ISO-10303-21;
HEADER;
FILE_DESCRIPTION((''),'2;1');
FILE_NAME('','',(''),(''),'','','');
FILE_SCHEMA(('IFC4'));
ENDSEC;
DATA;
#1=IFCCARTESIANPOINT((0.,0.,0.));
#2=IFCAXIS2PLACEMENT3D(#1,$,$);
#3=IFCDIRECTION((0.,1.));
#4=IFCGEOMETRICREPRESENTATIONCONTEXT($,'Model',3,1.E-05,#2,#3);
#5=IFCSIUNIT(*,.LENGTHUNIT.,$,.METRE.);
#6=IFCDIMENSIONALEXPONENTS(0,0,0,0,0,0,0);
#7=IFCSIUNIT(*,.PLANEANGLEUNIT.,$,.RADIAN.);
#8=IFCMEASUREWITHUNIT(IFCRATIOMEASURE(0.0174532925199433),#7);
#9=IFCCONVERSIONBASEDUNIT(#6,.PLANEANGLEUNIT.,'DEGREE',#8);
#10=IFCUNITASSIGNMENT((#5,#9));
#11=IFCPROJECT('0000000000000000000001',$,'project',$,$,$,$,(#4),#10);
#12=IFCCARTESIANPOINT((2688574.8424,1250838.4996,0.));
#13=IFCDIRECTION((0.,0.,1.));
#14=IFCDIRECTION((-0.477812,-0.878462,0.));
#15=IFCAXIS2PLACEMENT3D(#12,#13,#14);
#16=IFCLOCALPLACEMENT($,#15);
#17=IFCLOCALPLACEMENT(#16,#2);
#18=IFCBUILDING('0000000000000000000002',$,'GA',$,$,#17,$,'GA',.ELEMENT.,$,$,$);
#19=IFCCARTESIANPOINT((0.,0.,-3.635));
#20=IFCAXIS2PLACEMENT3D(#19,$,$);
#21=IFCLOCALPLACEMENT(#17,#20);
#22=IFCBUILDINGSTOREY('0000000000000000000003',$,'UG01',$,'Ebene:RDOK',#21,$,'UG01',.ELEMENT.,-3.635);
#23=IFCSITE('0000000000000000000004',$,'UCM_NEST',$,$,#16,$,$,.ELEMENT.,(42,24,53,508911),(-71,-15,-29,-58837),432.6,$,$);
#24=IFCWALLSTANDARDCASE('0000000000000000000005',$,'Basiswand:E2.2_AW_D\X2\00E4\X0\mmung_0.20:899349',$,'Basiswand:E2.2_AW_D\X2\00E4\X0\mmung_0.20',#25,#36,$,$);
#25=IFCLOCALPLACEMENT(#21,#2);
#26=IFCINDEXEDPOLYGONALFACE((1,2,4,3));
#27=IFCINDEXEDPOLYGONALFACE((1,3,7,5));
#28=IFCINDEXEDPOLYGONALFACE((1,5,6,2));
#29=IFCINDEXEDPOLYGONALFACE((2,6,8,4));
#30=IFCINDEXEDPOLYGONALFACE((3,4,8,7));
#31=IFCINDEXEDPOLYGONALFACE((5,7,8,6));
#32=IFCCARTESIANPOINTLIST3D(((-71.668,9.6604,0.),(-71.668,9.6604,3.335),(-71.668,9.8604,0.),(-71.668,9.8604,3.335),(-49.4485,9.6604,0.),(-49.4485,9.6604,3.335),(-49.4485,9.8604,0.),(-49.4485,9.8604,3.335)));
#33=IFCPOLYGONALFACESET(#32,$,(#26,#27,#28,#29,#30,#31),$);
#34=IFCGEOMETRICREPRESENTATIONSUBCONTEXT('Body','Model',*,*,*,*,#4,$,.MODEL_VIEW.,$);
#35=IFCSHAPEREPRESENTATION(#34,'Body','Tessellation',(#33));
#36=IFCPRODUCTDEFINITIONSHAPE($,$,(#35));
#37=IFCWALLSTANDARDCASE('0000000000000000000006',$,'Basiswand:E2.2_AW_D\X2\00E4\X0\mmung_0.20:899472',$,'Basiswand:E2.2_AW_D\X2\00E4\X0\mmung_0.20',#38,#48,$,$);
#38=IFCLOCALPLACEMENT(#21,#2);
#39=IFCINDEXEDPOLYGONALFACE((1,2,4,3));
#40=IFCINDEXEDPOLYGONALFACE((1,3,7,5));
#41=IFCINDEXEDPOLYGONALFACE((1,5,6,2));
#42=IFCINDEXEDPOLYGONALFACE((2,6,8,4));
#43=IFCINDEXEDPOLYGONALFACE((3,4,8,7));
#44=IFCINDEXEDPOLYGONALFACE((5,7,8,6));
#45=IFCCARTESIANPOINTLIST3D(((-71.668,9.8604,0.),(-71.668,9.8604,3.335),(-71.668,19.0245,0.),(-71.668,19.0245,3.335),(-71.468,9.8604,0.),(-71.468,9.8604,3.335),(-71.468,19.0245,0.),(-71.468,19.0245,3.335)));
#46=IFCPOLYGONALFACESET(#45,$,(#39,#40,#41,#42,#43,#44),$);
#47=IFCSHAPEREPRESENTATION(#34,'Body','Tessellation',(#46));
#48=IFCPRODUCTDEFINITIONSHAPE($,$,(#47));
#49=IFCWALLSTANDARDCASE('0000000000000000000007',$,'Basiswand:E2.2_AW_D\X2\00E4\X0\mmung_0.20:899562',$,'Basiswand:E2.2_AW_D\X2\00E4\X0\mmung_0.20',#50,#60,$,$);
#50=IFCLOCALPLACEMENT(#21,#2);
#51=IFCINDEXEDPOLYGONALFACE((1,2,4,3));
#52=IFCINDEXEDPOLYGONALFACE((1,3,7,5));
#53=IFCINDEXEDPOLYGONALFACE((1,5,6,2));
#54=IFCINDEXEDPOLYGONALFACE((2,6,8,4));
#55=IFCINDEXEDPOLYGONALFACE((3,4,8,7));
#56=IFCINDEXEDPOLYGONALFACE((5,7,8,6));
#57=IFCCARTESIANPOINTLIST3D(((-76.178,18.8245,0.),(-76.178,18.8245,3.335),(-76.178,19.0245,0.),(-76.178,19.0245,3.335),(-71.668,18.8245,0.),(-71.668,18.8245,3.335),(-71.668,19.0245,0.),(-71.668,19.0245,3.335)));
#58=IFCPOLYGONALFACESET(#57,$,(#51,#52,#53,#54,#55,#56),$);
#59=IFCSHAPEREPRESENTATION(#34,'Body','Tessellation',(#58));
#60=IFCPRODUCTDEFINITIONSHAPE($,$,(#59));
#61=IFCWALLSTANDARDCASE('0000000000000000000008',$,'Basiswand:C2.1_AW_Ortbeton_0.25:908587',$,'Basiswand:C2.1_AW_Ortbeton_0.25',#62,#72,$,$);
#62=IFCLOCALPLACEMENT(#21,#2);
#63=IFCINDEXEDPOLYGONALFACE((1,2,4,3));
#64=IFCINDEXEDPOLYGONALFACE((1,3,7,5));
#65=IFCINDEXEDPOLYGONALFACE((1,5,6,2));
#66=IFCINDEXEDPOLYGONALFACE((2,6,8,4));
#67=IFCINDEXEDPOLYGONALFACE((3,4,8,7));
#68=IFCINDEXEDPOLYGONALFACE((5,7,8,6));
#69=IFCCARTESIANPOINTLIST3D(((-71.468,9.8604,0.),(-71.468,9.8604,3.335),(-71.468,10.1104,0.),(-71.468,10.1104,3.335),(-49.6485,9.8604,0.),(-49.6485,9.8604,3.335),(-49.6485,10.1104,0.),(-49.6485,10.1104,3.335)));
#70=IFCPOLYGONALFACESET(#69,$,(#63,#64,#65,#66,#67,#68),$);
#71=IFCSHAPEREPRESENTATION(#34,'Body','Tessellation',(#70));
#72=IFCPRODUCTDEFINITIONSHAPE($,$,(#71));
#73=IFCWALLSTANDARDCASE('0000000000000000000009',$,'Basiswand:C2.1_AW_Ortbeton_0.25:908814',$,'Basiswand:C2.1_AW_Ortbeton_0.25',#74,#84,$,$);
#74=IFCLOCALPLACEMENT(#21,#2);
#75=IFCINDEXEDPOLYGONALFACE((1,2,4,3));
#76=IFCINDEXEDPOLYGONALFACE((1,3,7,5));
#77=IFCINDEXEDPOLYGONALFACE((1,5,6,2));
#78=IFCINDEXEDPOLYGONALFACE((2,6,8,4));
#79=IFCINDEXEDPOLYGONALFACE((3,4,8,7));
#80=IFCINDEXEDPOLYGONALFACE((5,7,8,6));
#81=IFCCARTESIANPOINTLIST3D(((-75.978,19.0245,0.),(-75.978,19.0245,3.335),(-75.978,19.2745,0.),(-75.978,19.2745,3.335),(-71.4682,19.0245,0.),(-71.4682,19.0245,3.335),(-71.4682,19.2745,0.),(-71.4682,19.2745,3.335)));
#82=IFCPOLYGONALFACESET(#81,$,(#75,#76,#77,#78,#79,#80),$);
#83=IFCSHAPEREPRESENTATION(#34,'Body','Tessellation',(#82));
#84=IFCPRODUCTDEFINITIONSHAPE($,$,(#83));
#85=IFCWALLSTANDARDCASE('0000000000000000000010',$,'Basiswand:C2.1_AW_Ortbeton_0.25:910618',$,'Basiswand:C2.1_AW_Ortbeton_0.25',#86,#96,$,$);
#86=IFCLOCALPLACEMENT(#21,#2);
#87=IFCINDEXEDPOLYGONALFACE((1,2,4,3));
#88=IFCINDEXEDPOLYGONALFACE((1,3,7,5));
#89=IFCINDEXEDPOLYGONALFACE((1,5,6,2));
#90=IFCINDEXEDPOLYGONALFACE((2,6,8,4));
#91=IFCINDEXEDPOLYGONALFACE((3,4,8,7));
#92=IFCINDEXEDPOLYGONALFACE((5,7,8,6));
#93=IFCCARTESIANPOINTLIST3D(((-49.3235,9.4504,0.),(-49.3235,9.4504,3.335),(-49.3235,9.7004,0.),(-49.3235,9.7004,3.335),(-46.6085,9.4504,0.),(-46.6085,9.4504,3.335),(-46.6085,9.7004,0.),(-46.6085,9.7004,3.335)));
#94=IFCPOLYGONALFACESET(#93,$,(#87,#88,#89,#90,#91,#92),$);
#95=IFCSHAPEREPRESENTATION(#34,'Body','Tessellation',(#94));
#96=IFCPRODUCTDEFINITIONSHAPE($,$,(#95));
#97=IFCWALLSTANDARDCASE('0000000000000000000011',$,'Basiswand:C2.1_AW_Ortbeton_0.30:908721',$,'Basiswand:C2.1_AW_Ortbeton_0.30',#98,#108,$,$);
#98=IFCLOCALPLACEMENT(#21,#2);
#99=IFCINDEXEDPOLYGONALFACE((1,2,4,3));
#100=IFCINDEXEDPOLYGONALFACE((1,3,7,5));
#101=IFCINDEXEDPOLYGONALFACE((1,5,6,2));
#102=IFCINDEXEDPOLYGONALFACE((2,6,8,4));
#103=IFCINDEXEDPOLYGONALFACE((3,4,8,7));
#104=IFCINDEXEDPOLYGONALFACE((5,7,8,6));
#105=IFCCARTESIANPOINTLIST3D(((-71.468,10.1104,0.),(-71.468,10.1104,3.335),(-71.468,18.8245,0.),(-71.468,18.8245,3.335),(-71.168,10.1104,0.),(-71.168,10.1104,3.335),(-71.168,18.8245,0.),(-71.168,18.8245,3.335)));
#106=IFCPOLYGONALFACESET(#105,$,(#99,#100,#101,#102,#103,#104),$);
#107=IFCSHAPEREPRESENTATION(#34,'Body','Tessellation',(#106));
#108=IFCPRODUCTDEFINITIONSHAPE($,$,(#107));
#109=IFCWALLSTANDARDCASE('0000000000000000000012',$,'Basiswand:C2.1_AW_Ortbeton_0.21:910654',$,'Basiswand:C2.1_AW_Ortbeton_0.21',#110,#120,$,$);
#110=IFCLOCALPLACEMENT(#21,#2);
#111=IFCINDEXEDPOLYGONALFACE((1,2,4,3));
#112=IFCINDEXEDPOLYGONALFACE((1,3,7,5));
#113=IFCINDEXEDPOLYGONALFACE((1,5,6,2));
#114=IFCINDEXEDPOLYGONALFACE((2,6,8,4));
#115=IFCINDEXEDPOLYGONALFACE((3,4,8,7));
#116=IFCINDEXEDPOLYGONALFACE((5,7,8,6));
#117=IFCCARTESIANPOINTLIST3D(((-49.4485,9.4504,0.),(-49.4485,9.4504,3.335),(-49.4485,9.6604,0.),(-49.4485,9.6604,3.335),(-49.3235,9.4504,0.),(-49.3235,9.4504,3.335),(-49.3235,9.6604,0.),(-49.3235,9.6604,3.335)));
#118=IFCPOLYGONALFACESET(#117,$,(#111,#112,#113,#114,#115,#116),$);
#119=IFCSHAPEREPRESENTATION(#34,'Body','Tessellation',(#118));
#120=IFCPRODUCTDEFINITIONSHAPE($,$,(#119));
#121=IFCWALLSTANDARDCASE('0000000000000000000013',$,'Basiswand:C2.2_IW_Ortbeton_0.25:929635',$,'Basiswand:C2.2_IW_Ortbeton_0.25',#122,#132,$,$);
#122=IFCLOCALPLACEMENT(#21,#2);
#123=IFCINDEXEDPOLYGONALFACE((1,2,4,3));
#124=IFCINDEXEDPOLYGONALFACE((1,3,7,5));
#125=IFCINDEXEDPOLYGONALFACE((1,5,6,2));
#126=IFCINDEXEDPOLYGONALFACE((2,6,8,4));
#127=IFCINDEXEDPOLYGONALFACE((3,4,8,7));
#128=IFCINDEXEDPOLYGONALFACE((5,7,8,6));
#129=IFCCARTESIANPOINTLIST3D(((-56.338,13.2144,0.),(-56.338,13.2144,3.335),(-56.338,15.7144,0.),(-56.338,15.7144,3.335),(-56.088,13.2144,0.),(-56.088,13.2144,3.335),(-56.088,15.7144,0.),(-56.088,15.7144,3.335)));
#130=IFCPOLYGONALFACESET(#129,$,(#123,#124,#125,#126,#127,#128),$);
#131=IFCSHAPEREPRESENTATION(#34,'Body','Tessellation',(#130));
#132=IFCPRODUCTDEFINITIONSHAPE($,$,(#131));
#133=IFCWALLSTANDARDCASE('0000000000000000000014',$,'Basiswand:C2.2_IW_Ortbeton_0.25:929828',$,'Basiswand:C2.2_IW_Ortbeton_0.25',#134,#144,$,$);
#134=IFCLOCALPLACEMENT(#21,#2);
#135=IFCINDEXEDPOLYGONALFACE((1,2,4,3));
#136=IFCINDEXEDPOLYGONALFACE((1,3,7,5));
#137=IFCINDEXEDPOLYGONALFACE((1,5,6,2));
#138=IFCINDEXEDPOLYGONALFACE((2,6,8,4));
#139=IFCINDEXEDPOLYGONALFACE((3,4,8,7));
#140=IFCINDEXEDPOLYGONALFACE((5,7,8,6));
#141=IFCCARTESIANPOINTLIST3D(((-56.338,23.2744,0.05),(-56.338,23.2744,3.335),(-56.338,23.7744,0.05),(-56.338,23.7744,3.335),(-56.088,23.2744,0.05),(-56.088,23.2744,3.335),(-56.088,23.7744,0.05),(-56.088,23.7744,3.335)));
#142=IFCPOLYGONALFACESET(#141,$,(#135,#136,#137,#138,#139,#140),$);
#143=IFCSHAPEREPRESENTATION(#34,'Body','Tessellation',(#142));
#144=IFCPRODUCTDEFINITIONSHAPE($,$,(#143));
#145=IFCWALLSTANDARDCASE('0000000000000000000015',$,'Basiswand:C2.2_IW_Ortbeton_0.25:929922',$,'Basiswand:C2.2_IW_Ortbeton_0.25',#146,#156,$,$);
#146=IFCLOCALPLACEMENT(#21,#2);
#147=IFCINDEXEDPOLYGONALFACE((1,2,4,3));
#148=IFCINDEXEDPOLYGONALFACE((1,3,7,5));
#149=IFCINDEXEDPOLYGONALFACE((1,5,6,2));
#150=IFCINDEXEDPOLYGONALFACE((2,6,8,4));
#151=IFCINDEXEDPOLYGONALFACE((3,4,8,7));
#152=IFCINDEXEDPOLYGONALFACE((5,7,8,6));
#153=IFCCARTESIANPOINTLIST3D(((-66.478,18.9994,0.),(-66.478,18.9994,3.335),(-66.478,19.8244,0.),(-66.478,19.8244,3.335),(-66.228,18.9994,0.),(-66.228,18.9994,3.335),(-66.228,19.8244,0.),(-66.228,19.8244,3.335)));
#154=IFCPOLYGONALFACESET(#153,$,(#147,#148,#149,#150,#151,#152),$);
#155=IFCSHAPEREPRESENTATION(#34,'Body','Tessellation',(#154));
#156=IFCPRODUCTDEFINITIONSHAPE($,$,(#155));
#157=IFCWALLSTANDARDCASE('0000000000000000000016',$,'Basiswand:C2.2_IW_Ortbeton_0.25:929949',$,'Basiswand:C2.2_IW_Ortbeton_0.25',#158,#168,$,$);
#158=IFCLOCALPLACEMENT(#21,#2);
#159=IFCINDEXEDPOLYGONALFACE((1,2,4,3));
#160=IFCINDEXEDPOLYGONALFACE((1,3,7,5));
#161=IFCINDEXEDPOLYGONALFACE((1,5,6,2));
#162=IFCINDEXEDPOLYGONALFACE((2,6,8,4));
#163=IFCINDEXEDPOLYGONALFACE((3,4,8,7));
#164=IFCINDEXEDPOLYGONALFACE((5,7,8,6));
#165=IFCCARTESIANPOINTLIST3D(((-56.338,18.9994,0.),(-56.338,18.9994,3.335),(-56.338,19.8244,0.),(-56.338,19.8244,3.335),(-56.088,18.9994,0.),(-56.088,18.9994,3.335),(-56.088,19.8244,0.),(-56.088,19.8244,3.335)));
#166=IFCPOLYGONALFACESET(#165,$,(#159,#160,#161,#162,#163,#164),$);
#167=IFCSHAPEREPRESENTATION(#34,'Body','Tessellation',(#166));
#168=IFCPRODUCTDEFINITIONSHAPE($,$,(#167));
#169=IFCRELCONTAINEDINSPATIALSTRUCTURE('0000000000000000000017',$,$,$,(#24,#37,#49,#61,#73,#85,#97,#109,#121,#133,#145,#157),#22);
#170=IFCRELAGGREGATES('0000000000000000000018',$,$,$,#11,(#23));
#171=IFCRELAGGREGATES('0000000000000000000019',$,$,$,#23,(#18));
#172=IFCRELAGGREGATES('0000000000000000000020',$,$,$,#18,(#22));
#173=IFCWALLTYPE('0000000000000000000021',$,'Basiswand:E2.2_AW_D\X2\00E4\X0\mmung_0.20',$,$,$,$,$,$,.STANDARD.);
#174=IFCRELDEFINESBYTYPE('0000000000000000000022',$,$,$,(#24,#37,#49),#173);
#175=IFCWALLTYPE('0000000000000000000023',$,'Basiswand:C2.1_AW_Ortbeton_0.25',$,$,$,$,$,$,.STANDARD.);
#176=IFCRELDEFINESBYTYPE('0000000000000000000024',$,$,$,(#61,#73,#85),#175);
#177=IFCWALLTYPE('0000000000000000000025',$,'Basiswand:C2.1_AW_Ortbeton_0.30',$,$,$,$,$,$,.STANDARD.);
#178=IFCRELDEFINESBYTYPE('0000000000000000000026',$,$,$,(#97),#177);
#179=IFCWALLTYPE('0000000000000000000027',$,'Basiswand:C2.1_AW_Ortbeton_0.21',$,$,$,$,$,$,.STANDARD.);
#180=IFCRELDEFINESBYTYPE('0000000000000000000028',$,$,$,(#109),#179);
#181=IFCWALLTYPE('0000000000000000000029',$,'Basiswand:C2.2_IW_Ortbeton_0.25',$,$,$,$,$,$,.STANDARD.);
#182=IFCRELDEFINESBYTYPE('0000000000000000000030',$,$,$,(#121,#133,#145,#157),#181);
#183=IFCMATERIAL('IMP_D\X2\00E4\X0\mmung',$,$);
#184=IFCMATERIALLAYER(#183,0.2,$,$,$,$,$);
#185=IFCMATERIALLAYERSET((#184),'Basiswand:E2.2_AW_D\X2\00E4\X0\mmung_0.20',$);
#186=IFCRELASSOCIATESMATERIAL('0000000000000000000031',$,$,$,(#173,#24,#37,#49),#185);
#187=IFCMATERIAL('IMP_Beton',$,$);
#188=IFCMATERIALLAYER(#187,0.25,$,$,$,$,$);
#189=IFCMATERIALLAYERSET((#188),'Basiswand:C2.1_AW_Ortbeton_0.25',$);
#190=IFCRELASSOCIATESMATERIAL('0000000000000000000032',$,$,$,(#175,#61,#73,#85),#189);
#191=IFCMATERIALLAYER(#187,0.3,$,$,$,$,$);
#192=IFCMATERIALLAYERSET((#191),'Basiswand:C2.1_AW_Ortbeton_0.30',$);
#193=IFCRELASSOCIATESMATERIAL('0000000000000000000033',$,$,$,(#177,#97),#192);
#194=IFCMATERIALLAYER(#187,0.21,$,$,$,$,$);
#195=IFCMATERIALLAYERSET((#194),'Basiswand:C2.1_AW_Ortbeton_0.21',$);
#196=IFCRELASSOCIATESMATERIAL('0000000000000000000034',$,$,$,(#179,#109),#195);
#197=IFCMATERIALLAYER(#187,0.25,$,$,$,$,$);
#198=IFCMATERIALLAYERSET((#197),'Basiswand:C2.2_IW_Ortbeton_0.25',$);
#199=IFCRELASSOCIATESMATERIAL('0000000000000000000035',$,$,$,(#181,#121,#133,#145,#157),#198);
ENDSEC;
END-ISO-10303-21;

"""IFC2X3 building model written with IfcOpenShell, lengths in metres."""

from ifc_helpers import new_model, entity, si_unit, converted_unit, direction, frame, frame_2d, origin, place, context, subcontext, project, spatial, polyline, rectangle, extrude, clip, bounded_halfspace, material, layer, layer_set, layer_usage, type_object, element, save


model = new_model("IFC2X3")

# Units and contexts
model_context = context("Model", 3, precision=1e-05, world=origin(), true_north=direction((0.0, 1.0)))
body_context = subcontext(model_context, "Body", "Model", "MODEL_VIEW")
ifc_project = project(units=[si_unit("LENGTHUNIT", "METRE"), converted_unit("PLANEANGLEUNIT", "DEGREE", entity("IfcRatioMeasure", 0.0174532925199433), si_unit("PLANEANGLEUNIT", "RADIAN"), dimensions=[0, 0, 0, 0, 0, 0, 0])], contexts=[model_context])

# Site, building, storey
site_placement = place(None, frame((2688574.8424, 1250838.4996, 0.0), z_axis=(0.0, 0.0, 1.0), x_axis=(-0.477812, -0.878462, 0.0)))
site = spatial("IfcSite", under=ifc_project, at=site_placement, Name="UCM_NEST", CompositionType="ELEMENT", RefLatitude=(42, 24, 53, 508911), RefLongitude=(-71, -15, -29, -58837), RefElevation=432.6)
building_placement = place(site_placement, origin())
building = spatial("IfcBuilding", under=site, at=building_placement, Name="GA", LongName="GA", CompositionType="ELEMENT")
storey_placement = place(building_placement, frame((0.0, 0.0, -3.635)))
storey = spatial("IfcBuildingStorey", under=building, at=storey_placement, Name="UG01", ObjectType="Ebene:RDOK", LongName="UG01", CompositionType="ELEMENT", Elevation=-3.635)

# Walls
ifc_material_1 = material(Name="IMP_Dämmung")
ifc_layer_1 = layer(ifc_material_1, 0.2)
ifc_layer_set_1 = layer_set([ifc_layer_1], Name="Basiswand:E2.2_AW_Dämmung_0.20")
ifc_layer_usage_1 = layer_usage(ifc_layer_set_1, "AXIS2", "NEGATIVE", 0.1)
wall_type_1 = type_object("IfcWallType", Name="Basiswand:E2.2_AW_Dämmung_0.20", PredefinedType="STANDARD", material=ifc_layer_set_1)
wall_1_placement = place(storey_placement, frame((-49.4485, 9.7604, 0.0), z_axis=(0.0, 0.0, 1.0), x_axis=(-1.0, 0.0, 0.0)))
element("IfcWallStandardCase", 1, at=wall_1_placement, inside=storey, type_object=wall_type_1, material=ifc_layer_usage_1, Name="Basiswand:E2.2_AW_Dämmung_0.20:899349", ObjectType="Basiswand:E2.2_AW_Dämmung_0.20", context=body_context, shape_type="SweptSolid", body=[
    extrude(rectangle(XDim=22.2195, YDim=0.2, at=frame_2d((11.1097, 0.0), x_axis=(-1.0, 0.0))), origin(), (0.0, 0.0, 1.0), 3.335),
])
ifc_layer_usage_2 = layer_usage(ifc_layer_set_1, "AXIS2", "NEGATIVE", 0.1)
wall_2_placement = place(storey_placement, frame((-71.568, 9.8604, 0.0), z_axis=(0.0, 0.0, 1.0), x_axis=(0.0, 1.0, 0.0)))
element("IfcWallStandardCase", 2, at=wall_2_placement, inside=storey, type_object=wall_type_1, material=ifc_layer_usage_2, Name="Basiswand:E2.2_AW_Dämmung_0.20:899472", ObjectType="Basiswand:E2.2_AW_Dämmung_0.20", context=body_context, shape_type="SweptSolid", body=[
    extrude(rectangle(XDim=9.164, YDim=0.2, at=frame_2d((4.582, 0.0), x_axis=(-1.0, 0.0))), origin(), (0.0, 0.0, 1.0), 3.335),
])
ifc_layer_usage_3 = layer_usage(ifc_layer_set_1, "AXIS2", "NEGATIVE", 0.1)
wall_3_placement = place(storey_placement, frame((-71.668, 18.9245, 0.0), z_axis=(0.0, 0.0, 1.0), x_axis=(-1.0, 0.0, 0.0)))
element("IfcWallStandardCase", 3, at=wall_3_placement, inside=storey, type_object=wall_type_1, material=ifc_layer_usage_3, Name="Basiswand:E2.2_AW_Dämmung_0.20:899562", ObjectType="Basiswand:E2.2_AW_Dämmung_0.20", context=body_context, shape_type="SweptSolid", body=[
    extrude(rectangle(XDim=4.51, YDim=0.2, at=frame_2d((2.255, 0.0), x_axis=(-1.0, 0.0))), origin(), (0.0, 0.0, 1.0), 3.335),
])
ifc_material_2 = material(Name="IMP_Beton")
ifc_layer_2 = layer(ifc_material_2, 0.25)
ifc_layer_set_2 = layer_set([ifc_layer_2], Name="Basiswand:C2.1_AW_Ortbeton_0.25")
ifc_layer_usage_4 = layer_usage(ifc_layer_set_2, "AXIS2", "NEGATIVE", 0.125)
wall_type_2 = type_object("IfcWallType", Name="Basiswand:C2.1_AW_Ortbeton_0.25", PredefinedType="STANDARD", material=ifc_layer_set_2)
wall_4_placement = place(storey_placement, frame((-71.468, 9.9854, 0.0)))
element("IfcWallStandardCase", 4, at=wall_4_placement, inside=storey, type_object=wall_type_2, material=ifc_layer_usage_4, Name="Basiswand:C2.1_AW_Ortbeton_0.25:908587", ObjectType="Basiswand:C2.1_AW_Ortbeton_0.25", context=body_context, shape_type="SweptSolid", body=[
    extrude(rectangle(XDim=21.8195, YDim=0.25, at=frame_2d((10.9097, 0.0), x_axis=(-1.0, 0.0))), origin(), (0.0, 0.0, 1.0), 3.335),
])
ifc_layer_usage_5 = layer_usage(ifc_layer_set_2, "AXIS2", "NEGATIVE", 0.125)
wall_5_placement = place(storey_placement, frame((-71.4682, 19.1495, 0.0), z_axis=(0.0, 0.0, 1.0), x_axis=(-1.0, 0.0, 0.0)))
element("IfcWallStandardCase", 5, at=wall_5_placement, inside=storey, type_object=wall_type_2, material=ifc_layer_usage_5, Name="Basiswand:C2.1_AW_Ortbeton_0.25:908814", ObjectType="Basiswand:C2.1_AW_Ortbeton_0.25", context=body_context, shape_type="SweptSolid", body=[
    extrude(rectangle(XDim=4.5097, YDim=0.25, at=frame_2d((2.2549, 0.0), x_axis=(-1.0, 0.0))), origin(), (0.0, 0.0, 1.0), 3.335),
])
ifc_layer_usage_6 = layer_usage(ifc_layer_set_2, "AXIS2", "NEGATIVE", 0.125)
wall_6_placement = place(storey_placement, frame((-46.6085, 9.5754, 0.0), z_axis=(0.0, 0.0, 1.0), x_axis=(-1.0, 0.0, 0.0)))
element("IfcWallStandardCase", 6, at=wall_6_placement, inside=storey, type_object=wall_type_2, material=ifc_layer_usage_6, Name="Basiswand:C2.1_AW_Ortbeton_0.25:910618", ObjectType="Basiswand:C2.1_AW_Ortbeton_0.25", context=body_context, shape_type="SweptSolid", body=[
    extrude(rectangle(XDim=2.715, YDim=0.25, at=frame_2d((1.3575, 0.0), x_axis=(-1.0, 0.0))), origin(), (0.0, 0.0, 1.0), 3.335),
])
ifc_layer_3 = layer(ifc_material_2, 0.3)
ifc_layer_set_3 = layer_set([ifc_layer_3], Name="Basiswand:C2.1_AW_Ortbeton_0.30")
ifc_layer_usage_7 = layer_usage(ifc_layer_set_3, "AXIS2", "NEGATIVE", 0.15)
wall_type_3 = type_object("IfcWallType", Name="Basiswand:C2.1_AW_Ortbeton_0.30", PredefinedType="STANDARD", material=ifc_layer_set_3)
wall_7_placement = place(storey_placement, frame((-71.318, 10.1104, 0.0), z_axis=(0.0, 0.0, 1.0), x_axis=(0.0, 1.0, 0.0)))
element("IfcWallStandardCase", 7, at=wall_7_placement, inside=storey, type_object=wall_type_3, material=ifc_layer_usage_7, Name="Basiswand:C2.1_AW_Ortbeton_0.30:908721", ObjectType="Basiswand:C2.1_AW_Ortbeton_0.30", context=body_context, shape_type="SweptSolid", body=[
    extrude(rectangle(XDim=8.714, YDim=0.3, at=frame_2d((4.357, 0.0), x_axis=(-1.0, 0.0))), origin(), (0.0, 0.0, 1.0), 3.335),
])
ifc_layer_4 = layer(ifc_material_2, 0.21)
ifc_layer_set_4 = layer_set([ifc_layer_4], Name="Basiswand:C2.1_AW_Ortbeton_0.21")
ifc_layer_usage_8 = layer_usage(ifc_layer_set_4, "AXIS2", "NEGATIVE", 0.105)
wall_type_4 = type_object("IfcWallType", Name="Basiswand:C2.1_AW_Ortbeton_0.21", PredefinedType="STANDARD", material=ifc_layer_set_4)
wall_8_placement = place(storey_placement, frame((-49.3235, 9.5554, 0.0), z_axis=(0.0, 0.0, 1.0), x_axis=(-1.0, 0.0, 0.0)))
element("IfcWallStandardCase", 8, at=wall_8_placement, inside=storey, type_object=wall_type_4, material=ifc_layer_usage_8, Name="Basiswand:C2.1_AW_Ortbeton_0.21:910654", ObjectType="Basiswand:C2.1_AW_Ortbeton_0.21", context=body_context, shape_type="SweptSolid", body=[
    extrude(rectangle(XDim=0.125, YDim=0.21, at=frame_2d((0.0625, 0.0), x_axis=(-1.0, 0.0))), origin(), (0.0, 0.0, 1.0), 3.335),
])
ifc_layer_5 = layer(ifc_material_2, 0.25)
ifc_layer_set_5 = layer_set([ifc_layer_5], Name="Basiswand:C2.2_IW_Ortbeton_0.25")
ifc_layer_usage_9 = layer_usage(ifc_layer_set_5, "AXIS2", "NEGATIVE", 0.125)
wall_type_5 = type_object("IfcWallType", Name="Basiswand:C2.2_IW_Ortbeton_0.25", PredefinedType="STANDARD", material=ifc_layer_set_5)
wall_9_placement = place(storey_placement, frame((-56.213, 13.2144, 0.0), z_axis=(0.0, 0.0, 1.0), x_axis=(0.0, 1.0, 0.0)))
element("IfcWallStandardCase", 9, at=wall_9_placement, inside=storey, type_object=wall_type_5, material=ifc_layer_usage_9, Name="Basiswand:C2.2_IW_Ortbeton_0.25:929635", ObjectType="Basiswand:C2.2_IW_Ortbeton_0.25", context=body_context, shape_type="SweptSolid", body=[
    extrude(rectangle(XDim=2.5, YDim=0.25, at=frame_2d((1.25, 0.0), x_axis=(-1.0, 0.0))), origin(), (0.0, 0.0, 1.0), 3.335),
])
ifc_layer_usage_10 = layer_usage(ifc_layer_set_5, "AXIS2", "NEGATIVE", 0.125)
wall_10_placement = place(storey_placement, frame((-56.213, 23.7744, 0.05), z_axis=(0.0, 0.0, 1.0), x_axis=(0.0, -1.0, 0.0)))
element("IfcWallStandardCase", 10, at=wall_10_placement, inside=storey, type_object=wall_type_5, material=ifc_layer_usage_10, Name="Basiswand:C2.2_IW_Ortbeton_0.25:929828", ObjectType="Basiswand:C2.2_IW_Ortbeton_0.25", context=body_context, shape_type="Clipping", body=[
    clip(extrude(rectangle(XDim=0.5, YDim=0.25, at=frame_2d((0.25, 0.0), x_axis=(-1.0, 0.0))), origin(), (0.0, 0.0, 1.0), 3.285), bounded_halfspace(frame((0.5, -0.125, 0.0), z_axis=(0.0, 0.0, 1.0), x_axis=(-1.0, 0.0, 0.0)), True, frame((0.5, -0.125, 0.0), z_axis=(0.0, 0.0, 1.0), x_axis=(-1.0, 0.0, 0.0)), polyline([(0.0, 0.0), (0.0, -0.25), (0.5, -0.25), (0.5, 0.0), (0.0, 0.0)]))),
])
ifc_layer_usage_11 = layer_usage(ifc_layer_set_5, "AXIS2", "NEGATIVE", 0.125)
wall_11_placement = place(storey_placement, frame((-66.353, 19.8244, 0.0), z_axis=(0.0, 0.0, 1.0), x_axis=(0.0, -1.0, 0.0)))
element("IfcWallStandardCase", 11, at=wall_11_placement, inside=storey, type_object=wall_type_5, material=ifc_layer_usage_11, Name="Basiswand:C2.2_IW_Ortbeton_0.25:929922", ObjectType="Basiswand:C2.2_IW_Ortbeton_0.25", context=body_context, shape_type="SweptSolid", body=[
    extrude(rectangle(XDim=0.825, YDim=0.25, at=frame_2d((0.4125, 0.0), x_axis=(-1.0, 0.0))), origin(), (0.0, 0.0, 1.0), 3.335),
])
ifc_layer_usage_12 = layer_usage(ifc_layer_set_5, "AXIS2", "NEGATIVE", 0.125)
wall_12_placement = place(storey_placement, frame((-56.213, 19.8244, 0.0), z_axis=(0.0, 0.0, 1.0), x_axis=(0.0, -1.0, 0.0)))
element("IfcWallStandardCase", 12, at=wall_12_placement, inside=storey, type_object=wall_type_5, material=ifc_layer_usage_12, Name="Basiswand:C2.2_IW_Ortbeton_0.25:929949", ObjectType="Basiswand:C2.2_IW_Ortbeton_0.25", context=body_context, shape_type="SweptSolid", body=[
    extrude(rectangle(XDim=0.825, YDim=0.25, at=frame_2d((0.4125, 0.0), x_axis=(-1.0, 0.0))), origin(), (0.0, 0.0, 1.0), 3.335),
])

save(model, "model.ifc")
